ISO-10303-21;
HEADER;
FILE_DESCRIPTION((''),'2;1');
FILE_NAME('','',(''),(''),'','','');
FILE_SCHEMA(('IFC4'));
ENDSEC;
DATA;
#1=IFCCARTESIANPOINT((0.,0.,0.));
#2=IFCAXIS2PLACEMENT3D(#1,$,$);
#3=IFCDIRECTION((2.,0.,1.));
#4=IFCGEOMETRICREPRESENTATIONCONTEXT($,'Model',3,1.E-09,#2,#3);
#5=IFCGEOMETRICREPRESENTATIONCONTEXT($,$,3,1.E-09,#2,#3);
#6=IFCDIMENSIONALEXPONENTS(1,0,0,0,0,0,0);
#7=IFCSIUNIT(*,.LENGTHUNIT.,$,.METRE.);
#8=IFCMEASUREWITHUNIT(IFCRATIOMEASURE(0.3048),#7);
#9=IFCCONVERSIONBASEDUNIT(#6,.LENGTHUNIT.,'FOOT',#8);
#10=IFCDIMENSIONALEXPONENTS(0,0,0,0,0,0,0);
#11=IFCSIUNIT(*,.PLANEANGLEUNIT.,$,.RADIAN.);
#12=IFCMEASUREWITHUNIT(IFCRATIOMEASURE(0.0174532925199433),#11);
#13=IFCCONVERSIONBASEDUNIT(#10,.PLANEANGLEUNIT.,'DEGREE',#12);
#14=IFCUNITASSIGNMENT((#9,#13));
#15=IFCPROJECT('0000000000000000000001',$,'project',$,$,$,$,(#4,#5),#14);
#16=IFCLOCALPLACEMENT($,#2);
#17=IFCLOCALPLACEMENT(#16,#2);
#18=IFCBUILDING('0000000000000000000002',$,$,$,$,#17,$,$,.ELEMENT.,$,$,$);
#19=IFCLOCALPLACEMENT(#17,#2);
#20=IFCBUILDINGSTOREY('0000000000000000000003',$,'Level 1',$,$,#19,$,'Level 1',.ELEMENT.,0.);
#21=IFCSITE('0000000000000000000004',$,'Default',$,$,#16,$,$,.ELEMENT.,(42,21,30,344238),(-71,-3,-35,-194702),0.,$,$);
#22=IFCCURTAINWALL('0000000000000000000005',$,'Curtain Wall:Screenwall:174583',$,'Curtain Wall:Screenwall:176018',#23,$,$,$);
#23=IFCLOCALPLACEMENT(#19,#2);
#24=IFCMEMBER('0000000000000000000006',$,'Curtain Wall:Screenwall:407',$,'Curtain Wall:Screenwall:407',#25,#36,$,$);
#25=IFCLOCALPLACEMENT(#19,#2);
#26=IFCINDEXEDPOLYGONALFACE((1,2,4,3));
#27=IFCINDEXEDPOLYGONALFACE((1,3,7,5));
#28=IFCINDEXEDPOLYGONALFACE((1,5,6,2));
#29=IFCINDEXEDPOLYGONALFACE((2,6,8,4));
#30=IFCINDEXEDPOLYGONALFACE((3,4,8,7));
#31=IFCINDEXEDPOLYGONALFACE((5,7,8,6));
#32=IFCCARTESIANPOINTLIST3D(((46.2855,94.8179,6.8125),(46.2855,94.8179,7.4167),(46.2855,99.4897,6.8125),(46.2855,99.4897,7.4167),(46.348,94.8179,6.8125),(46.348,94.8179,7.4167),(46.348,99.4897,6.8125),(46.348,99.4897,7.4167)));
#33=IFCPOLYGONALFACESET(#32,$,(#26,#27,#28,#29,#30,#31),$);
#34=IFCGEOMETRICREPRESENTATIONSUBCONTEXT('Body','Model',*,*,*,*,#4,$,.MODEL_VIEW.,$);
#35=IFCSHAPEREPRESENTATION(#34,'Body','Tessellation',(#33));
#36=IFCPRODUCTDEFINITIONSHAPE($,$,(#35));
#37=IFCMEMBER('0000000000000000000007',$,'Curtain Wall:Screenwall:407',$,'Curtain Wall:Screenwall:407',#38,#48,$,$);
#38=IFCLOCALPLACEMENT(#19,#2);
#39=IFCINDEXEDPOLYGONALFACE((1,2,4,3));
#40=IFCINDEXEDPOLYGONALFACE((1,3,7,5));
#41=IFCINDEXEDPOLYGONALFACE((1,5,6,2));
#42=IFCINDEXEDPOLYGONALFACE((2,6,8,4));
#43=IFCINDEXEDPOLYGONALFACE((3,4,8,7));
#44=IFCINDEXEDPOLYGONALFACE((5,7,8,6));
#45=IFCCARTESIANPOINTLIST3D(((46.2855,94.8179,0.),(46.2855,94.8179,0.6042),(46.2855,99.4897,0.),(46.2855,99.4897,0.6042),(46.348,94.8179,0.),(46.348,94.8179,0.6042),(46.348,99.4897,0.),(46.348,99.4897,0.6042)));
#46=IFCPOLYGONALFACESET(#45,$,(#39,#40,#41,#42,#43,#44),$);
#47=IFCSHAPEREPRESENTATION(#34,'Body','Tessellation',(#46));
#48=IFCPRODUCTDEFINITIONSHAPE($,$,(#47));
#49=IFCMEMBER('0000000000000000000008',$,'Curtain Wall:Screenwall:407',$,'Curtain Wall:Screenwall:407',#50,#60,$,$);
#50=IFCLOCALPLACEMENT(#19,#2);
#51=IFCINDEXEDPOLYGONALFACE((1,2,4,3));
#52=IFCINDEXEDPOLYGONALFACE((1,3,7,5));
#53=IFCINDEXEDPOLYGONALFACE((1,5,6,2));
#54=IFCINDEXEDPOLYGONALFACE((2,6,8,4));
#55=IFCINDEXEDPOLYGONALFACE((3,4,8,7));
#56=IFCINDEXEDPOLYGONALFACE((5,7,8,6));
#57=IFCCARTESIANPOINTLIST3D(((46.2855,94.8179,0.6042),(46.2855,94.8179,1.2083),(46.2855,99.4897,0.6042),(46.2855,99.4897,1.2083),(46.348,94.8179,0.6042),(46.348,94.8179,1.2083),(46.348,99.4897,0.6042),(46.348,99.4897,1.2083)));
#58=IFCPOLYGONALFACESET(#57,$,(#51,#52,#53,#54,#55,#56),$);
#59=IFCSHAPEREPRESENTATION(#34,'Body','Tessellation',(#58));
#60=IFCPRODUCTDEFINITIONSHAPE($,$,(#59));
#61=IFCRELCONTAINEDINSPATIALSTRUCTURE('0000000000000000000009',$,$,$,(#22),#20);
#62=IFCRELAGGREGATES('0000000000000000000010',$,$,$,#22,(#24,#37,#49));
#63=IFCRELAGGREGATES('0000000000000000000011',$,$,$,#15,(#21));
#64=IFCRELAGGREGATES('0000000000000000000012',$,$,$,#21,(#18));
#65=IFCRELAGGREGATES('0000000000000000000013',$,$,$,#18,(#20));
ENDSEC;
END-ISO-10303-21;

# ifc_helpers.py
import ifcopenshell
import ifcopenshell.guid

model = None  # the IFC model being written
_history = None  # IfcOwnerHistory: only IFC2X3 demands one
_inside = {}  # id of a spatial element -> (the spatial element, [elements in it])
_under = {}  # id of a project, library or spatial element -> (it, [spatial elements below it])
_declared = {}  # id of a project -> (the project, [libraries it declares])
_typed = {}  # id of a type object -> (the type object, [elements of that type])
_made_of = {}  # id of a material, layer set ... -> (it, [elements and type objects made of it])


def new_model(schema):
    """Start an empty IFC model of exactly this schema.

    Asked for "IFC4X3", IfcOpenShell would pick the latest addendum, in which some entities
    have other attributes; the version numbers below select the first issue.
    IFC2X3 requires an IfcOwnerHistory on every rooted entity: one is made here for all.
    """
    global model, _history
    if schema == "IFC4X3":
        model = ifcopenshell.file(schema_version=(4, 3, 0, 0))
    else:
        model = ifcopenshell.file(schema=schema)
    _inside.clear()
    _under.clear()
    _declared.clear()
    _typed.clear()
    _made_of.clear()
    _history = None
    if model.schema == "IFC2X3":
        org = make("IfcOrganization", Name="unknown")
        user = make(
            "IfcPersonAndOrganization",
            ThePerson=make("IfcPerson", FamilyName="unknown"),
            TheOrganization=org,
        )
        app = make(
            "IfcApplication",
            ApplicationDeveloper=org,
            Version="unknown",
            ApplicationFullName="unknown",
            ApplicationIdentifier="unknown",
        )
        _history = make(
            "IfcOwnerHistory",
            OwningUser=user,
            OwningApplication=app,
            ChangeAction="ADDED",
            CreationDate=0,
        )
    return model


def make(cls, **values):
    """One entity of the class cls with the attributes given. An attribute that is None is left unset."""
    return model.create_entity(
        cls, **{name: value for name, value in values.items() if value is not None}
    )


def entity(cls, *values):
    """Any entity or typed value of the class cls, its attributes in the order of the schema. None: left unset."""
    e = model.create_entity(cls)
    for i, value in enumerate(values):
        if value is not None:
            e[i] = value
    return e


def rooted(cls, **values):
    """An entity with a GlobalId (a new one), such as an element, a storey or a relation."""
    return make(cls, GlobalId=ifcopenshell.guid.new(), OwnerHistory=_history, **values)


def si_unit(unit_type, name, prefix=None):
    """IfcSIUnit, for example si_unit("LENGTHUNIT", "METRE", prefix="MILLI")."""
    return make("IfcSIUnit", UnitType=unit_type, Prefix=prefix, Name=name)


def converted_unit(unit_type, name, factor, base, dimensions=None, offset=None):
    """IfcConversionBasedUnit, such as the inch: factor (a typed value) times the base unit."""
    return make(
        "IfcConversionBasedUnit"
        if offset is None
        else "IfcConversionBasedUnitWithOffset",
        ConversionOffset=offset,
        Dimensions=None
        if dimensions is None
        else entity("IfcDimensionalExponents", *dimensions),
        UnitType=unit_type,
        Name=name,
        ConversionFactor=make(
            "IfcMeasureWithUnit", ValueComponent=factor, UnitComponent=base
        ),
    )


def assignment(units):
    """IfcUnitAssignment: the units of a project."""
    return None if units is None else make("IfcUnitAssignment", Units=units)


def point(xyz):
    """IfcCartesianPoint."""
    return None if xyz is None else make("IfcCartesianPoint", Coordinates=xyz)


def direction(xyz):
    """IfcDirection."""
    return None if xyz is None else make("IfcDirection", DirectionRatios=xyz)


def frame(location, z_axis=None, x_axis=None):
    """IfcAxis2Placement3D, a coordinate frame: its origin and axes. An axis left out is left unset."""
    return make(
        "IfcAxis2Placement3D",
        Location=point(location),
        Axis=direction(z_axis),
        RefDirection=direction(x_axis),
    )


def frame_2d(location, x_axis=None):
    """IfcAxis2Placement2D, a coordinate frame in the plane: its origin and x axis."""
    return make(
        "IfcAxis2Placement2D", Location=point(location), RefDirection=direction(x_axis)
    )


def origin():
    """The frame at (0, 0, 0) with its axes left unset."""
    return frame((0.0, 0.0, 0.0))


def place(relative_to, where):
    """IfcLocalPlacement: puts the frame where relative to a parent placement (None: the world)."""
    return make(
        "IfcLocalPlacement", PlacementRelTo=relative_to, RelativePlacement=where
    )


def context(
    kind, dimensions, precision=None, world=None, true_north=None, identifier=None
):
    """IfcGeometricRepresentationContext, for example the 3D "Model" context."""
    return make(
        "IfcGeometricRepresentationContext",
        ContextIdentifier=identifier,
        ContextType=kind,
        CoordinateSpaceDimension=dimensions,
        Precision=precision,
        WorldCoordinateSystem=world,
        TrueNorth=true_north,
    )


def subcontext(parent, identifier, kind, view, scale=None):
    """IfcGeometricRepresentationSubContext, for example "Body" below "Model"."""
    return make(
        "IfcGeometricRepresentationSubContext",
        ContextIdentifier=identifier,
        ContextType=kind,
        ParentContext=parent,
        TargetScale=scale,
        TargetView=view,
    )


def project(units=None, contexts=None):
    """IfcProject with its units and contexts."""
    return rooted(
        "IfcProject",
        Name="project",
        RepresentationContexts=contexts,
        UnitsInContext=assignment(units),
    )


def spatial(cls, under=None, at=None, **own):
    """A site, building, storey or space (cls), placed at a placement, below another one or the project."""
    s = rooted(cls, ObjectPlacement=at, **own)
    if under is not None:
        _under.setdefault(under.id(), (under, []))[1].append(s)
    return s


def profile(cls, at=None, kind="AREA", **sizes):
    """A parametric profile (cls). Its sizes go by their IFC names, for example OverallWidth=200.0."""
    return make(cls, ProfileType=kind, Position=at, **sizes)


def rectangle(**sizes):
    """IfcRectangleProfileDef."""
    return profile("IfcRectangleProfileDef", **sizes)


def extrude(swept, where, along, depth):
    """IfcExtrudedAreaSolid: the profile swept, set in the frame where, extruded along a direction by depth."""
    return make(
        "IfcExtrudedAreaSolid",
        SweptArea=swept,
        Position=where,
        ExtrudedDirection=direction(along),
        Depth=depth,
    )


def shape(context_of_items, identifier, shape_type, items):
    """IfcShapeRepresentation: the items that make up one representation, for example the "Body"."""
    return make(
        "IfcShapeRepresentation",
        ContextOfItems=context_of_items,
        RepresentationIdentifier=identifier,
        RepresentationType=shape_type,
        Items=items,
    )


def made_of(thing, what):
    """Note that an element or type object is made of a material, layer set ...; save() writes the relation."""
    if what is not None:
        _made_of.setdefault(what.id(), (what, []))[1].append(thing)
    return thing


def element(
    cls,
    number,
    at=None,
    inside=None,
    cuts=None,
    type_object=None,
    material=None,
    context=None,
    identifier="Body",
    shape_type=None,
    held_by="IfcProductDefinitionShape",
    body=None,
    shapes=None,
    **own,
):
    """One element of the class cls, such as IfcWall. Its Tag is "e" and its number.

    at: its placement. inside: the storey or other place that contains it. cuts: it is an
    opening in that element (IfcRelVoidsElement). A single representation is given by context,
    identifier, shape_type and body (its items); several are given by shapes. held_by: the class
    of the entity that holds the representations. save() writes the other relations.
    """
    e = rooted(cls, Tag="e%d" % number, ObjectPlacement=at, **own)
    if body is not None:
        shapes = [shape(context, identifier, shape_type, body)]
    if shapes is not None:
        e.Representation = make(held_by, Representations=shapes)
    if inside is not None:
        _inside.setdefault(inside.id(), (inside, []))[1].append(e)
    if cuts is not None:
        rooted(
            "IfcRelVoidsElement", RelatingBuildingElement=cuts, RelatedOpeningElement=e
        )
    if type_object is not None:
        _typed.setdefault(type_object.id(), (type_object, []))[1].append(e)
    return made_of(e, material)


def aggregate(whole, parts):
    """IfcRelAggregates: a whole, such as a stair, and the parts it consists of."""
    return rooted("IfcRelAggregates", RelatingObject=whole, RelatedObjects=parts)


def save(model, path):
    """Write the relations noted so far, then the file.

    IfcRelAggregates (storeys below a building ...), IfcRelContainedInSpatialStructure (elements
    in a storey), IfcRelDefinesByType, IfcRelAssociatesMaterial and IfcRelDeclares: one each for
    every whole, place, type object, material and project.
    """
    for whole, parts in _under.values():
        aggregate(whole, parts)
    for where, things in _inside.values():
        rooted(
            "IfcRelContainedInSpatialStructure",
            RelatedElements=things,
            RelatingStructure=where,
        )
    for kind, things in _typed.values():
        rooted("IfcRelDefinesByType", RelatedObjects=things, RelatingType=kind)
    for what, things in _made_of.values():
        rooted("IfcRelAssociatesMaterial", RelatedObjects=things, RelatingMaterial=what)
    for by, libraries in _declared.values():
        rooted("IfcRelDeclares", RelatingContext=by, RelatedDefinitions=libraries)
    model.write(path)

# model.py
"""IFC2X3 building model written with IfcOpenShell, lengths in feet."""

from ifc_helpers import new_model, entity, si_unit, converted_unit, direction, frame, frame_2d, origin, place, context, subcontext, project, spatial, rectangle, extrude, element, aggregate, save


model = new_model("IFC2X3")

# Units and contexts
model_context = context("Model", 3, precision=1e-09, world=origin(), true_north=direction((2.0, 0.0, 1.0)))
context_of_model = context(None, 3, precision=1e-09, world=origin(), true_north=direction((2.0, 0.0, 1.0)))
body_context = subcontext(model_context, "Body", "Model", "MODEL_VIEW")
ifc_project = project(units=[converted_unit("LENGTHUNIT", "FOOT", entity("IfcRatioMeasure", 0.3048), si_unit("LENGTHUNIT", "METRE"), dimensions=[1, 0, 0, 0, 0, 0, 0]), converted_unit("PLANEANGLEUNIT", "DEGREE", entity("IfcRatioMeasure", 0.0174532925199433), si_unit("PLANEANGLEUNIT", "RADIAN"), dimensions=[0, 0, 0, 0, 0, 0, 0])], contexts=[model_context, context_of_model])

# Site, building, storey
site_placement = place(None, origin())
site = spatial("IfcSite", under=ifc_project, at=site_placement, Name="Default", CompositionType="ELEMENT", RefLatitude=(42, 21, 30, 344238), RefLongitude=(-71, -3, -35, -194702), RefElevation=0.0)
building_placement = place(site_placement, origin())
building = spatial("IfcBuilding", under=site, at=building_placement, CompositionType="ELEMENT")
storey_placement = place(building_placement, origin())
storey = spatial("IfcBuildingStorey", under=building, at=storey_placement, Name="Level 1", LongName="Level 1", CompositionType="ELEMENT", Elevation=0.0)

# Curtain wall, members
curtain_wall_1_placement = place(storey_placement, origin())
curtain_wall_1 = element("IfcCurtainWall", 1, at=curtain_wall_1_placement, inside=storey, Name="Curtain Wall:Screenwall:174583", ObjectType="Curtain Wall:Screenwall:176018")
member_1_placement = place(curtain_wall_1_placement, frame((46.2855, 94.8179, 6.8125)))
member_1 = element("IfcMember", 2, at=member_1_placement, Name="Curtain Wall:Screenwall:407", ObjectType="Curtain Wall:Screenwall:407", context=body_context, shape_type="SweptSolid", body=[
    extrude(rectangle(XDim=4.6717, YDim=0.0625, at=frame_2d((0.0, 0.0), x_axis=(1.0, 0.0))), frame((0.0312, 2.3359, 0.0), z_axis=(0.0, 0.0, 1.0), x_axis=(0.0, -1.0, 0.0)), (0.0, 0.0, 1.0), 0.6042),
])
member_2_placement = place(curtain_wall_1_placement, frame((46.2855, 94.8179, 0.0)))
member_2 = element("IfcMember", 3, at=member_2_placement, Name="Curtain Wall:Screenwall:407", ObjectType="Curtain Wall:Screenwall:407", context=body_context, shape_type="SweptSolid", body=[
    extrude(rectangle(XDim=4.6717, YDim=0.0625, at=frame_2d((0.0, 0.0), x_axis=(1.0, 0.0))), frame((0.0313, 2.3359, 0.0), z_axis=(0.0, 0.0, 1.0), x_axis=(0.0, 1.0, 0.0)), (0.0, 0.0, 1.0), 0.6042),
])
member_3_placement = place(curtain_wall_1_placement, frame((46.2855, 94.8179, 0.6042)))
member_3 = element("IfcMember", 4, at=member_3_placement, Name="Curtain Wall:Screenwall:407", ObjectType="Curtain Wall:Screenwall:407", context=body_context, shape_type="SweptSolid", body=[
    extrude(rectangle(XDim=4.6717, YDim=0.0625, at=frame_2d((0.0, 0.0), x_axis=(1.0, 0.0))), frame((0.0312, 2.3359, 0.0), z_axis=(0.0, 0.0, 1.0), x_axis=(0.0, -1.0, 0.0)), (0.0, 0.0, 1.0), 0.6042),
])
aggregate(curtain_wall_1, [member_1, member_2, member_3])

save(model, "model.ifc")
